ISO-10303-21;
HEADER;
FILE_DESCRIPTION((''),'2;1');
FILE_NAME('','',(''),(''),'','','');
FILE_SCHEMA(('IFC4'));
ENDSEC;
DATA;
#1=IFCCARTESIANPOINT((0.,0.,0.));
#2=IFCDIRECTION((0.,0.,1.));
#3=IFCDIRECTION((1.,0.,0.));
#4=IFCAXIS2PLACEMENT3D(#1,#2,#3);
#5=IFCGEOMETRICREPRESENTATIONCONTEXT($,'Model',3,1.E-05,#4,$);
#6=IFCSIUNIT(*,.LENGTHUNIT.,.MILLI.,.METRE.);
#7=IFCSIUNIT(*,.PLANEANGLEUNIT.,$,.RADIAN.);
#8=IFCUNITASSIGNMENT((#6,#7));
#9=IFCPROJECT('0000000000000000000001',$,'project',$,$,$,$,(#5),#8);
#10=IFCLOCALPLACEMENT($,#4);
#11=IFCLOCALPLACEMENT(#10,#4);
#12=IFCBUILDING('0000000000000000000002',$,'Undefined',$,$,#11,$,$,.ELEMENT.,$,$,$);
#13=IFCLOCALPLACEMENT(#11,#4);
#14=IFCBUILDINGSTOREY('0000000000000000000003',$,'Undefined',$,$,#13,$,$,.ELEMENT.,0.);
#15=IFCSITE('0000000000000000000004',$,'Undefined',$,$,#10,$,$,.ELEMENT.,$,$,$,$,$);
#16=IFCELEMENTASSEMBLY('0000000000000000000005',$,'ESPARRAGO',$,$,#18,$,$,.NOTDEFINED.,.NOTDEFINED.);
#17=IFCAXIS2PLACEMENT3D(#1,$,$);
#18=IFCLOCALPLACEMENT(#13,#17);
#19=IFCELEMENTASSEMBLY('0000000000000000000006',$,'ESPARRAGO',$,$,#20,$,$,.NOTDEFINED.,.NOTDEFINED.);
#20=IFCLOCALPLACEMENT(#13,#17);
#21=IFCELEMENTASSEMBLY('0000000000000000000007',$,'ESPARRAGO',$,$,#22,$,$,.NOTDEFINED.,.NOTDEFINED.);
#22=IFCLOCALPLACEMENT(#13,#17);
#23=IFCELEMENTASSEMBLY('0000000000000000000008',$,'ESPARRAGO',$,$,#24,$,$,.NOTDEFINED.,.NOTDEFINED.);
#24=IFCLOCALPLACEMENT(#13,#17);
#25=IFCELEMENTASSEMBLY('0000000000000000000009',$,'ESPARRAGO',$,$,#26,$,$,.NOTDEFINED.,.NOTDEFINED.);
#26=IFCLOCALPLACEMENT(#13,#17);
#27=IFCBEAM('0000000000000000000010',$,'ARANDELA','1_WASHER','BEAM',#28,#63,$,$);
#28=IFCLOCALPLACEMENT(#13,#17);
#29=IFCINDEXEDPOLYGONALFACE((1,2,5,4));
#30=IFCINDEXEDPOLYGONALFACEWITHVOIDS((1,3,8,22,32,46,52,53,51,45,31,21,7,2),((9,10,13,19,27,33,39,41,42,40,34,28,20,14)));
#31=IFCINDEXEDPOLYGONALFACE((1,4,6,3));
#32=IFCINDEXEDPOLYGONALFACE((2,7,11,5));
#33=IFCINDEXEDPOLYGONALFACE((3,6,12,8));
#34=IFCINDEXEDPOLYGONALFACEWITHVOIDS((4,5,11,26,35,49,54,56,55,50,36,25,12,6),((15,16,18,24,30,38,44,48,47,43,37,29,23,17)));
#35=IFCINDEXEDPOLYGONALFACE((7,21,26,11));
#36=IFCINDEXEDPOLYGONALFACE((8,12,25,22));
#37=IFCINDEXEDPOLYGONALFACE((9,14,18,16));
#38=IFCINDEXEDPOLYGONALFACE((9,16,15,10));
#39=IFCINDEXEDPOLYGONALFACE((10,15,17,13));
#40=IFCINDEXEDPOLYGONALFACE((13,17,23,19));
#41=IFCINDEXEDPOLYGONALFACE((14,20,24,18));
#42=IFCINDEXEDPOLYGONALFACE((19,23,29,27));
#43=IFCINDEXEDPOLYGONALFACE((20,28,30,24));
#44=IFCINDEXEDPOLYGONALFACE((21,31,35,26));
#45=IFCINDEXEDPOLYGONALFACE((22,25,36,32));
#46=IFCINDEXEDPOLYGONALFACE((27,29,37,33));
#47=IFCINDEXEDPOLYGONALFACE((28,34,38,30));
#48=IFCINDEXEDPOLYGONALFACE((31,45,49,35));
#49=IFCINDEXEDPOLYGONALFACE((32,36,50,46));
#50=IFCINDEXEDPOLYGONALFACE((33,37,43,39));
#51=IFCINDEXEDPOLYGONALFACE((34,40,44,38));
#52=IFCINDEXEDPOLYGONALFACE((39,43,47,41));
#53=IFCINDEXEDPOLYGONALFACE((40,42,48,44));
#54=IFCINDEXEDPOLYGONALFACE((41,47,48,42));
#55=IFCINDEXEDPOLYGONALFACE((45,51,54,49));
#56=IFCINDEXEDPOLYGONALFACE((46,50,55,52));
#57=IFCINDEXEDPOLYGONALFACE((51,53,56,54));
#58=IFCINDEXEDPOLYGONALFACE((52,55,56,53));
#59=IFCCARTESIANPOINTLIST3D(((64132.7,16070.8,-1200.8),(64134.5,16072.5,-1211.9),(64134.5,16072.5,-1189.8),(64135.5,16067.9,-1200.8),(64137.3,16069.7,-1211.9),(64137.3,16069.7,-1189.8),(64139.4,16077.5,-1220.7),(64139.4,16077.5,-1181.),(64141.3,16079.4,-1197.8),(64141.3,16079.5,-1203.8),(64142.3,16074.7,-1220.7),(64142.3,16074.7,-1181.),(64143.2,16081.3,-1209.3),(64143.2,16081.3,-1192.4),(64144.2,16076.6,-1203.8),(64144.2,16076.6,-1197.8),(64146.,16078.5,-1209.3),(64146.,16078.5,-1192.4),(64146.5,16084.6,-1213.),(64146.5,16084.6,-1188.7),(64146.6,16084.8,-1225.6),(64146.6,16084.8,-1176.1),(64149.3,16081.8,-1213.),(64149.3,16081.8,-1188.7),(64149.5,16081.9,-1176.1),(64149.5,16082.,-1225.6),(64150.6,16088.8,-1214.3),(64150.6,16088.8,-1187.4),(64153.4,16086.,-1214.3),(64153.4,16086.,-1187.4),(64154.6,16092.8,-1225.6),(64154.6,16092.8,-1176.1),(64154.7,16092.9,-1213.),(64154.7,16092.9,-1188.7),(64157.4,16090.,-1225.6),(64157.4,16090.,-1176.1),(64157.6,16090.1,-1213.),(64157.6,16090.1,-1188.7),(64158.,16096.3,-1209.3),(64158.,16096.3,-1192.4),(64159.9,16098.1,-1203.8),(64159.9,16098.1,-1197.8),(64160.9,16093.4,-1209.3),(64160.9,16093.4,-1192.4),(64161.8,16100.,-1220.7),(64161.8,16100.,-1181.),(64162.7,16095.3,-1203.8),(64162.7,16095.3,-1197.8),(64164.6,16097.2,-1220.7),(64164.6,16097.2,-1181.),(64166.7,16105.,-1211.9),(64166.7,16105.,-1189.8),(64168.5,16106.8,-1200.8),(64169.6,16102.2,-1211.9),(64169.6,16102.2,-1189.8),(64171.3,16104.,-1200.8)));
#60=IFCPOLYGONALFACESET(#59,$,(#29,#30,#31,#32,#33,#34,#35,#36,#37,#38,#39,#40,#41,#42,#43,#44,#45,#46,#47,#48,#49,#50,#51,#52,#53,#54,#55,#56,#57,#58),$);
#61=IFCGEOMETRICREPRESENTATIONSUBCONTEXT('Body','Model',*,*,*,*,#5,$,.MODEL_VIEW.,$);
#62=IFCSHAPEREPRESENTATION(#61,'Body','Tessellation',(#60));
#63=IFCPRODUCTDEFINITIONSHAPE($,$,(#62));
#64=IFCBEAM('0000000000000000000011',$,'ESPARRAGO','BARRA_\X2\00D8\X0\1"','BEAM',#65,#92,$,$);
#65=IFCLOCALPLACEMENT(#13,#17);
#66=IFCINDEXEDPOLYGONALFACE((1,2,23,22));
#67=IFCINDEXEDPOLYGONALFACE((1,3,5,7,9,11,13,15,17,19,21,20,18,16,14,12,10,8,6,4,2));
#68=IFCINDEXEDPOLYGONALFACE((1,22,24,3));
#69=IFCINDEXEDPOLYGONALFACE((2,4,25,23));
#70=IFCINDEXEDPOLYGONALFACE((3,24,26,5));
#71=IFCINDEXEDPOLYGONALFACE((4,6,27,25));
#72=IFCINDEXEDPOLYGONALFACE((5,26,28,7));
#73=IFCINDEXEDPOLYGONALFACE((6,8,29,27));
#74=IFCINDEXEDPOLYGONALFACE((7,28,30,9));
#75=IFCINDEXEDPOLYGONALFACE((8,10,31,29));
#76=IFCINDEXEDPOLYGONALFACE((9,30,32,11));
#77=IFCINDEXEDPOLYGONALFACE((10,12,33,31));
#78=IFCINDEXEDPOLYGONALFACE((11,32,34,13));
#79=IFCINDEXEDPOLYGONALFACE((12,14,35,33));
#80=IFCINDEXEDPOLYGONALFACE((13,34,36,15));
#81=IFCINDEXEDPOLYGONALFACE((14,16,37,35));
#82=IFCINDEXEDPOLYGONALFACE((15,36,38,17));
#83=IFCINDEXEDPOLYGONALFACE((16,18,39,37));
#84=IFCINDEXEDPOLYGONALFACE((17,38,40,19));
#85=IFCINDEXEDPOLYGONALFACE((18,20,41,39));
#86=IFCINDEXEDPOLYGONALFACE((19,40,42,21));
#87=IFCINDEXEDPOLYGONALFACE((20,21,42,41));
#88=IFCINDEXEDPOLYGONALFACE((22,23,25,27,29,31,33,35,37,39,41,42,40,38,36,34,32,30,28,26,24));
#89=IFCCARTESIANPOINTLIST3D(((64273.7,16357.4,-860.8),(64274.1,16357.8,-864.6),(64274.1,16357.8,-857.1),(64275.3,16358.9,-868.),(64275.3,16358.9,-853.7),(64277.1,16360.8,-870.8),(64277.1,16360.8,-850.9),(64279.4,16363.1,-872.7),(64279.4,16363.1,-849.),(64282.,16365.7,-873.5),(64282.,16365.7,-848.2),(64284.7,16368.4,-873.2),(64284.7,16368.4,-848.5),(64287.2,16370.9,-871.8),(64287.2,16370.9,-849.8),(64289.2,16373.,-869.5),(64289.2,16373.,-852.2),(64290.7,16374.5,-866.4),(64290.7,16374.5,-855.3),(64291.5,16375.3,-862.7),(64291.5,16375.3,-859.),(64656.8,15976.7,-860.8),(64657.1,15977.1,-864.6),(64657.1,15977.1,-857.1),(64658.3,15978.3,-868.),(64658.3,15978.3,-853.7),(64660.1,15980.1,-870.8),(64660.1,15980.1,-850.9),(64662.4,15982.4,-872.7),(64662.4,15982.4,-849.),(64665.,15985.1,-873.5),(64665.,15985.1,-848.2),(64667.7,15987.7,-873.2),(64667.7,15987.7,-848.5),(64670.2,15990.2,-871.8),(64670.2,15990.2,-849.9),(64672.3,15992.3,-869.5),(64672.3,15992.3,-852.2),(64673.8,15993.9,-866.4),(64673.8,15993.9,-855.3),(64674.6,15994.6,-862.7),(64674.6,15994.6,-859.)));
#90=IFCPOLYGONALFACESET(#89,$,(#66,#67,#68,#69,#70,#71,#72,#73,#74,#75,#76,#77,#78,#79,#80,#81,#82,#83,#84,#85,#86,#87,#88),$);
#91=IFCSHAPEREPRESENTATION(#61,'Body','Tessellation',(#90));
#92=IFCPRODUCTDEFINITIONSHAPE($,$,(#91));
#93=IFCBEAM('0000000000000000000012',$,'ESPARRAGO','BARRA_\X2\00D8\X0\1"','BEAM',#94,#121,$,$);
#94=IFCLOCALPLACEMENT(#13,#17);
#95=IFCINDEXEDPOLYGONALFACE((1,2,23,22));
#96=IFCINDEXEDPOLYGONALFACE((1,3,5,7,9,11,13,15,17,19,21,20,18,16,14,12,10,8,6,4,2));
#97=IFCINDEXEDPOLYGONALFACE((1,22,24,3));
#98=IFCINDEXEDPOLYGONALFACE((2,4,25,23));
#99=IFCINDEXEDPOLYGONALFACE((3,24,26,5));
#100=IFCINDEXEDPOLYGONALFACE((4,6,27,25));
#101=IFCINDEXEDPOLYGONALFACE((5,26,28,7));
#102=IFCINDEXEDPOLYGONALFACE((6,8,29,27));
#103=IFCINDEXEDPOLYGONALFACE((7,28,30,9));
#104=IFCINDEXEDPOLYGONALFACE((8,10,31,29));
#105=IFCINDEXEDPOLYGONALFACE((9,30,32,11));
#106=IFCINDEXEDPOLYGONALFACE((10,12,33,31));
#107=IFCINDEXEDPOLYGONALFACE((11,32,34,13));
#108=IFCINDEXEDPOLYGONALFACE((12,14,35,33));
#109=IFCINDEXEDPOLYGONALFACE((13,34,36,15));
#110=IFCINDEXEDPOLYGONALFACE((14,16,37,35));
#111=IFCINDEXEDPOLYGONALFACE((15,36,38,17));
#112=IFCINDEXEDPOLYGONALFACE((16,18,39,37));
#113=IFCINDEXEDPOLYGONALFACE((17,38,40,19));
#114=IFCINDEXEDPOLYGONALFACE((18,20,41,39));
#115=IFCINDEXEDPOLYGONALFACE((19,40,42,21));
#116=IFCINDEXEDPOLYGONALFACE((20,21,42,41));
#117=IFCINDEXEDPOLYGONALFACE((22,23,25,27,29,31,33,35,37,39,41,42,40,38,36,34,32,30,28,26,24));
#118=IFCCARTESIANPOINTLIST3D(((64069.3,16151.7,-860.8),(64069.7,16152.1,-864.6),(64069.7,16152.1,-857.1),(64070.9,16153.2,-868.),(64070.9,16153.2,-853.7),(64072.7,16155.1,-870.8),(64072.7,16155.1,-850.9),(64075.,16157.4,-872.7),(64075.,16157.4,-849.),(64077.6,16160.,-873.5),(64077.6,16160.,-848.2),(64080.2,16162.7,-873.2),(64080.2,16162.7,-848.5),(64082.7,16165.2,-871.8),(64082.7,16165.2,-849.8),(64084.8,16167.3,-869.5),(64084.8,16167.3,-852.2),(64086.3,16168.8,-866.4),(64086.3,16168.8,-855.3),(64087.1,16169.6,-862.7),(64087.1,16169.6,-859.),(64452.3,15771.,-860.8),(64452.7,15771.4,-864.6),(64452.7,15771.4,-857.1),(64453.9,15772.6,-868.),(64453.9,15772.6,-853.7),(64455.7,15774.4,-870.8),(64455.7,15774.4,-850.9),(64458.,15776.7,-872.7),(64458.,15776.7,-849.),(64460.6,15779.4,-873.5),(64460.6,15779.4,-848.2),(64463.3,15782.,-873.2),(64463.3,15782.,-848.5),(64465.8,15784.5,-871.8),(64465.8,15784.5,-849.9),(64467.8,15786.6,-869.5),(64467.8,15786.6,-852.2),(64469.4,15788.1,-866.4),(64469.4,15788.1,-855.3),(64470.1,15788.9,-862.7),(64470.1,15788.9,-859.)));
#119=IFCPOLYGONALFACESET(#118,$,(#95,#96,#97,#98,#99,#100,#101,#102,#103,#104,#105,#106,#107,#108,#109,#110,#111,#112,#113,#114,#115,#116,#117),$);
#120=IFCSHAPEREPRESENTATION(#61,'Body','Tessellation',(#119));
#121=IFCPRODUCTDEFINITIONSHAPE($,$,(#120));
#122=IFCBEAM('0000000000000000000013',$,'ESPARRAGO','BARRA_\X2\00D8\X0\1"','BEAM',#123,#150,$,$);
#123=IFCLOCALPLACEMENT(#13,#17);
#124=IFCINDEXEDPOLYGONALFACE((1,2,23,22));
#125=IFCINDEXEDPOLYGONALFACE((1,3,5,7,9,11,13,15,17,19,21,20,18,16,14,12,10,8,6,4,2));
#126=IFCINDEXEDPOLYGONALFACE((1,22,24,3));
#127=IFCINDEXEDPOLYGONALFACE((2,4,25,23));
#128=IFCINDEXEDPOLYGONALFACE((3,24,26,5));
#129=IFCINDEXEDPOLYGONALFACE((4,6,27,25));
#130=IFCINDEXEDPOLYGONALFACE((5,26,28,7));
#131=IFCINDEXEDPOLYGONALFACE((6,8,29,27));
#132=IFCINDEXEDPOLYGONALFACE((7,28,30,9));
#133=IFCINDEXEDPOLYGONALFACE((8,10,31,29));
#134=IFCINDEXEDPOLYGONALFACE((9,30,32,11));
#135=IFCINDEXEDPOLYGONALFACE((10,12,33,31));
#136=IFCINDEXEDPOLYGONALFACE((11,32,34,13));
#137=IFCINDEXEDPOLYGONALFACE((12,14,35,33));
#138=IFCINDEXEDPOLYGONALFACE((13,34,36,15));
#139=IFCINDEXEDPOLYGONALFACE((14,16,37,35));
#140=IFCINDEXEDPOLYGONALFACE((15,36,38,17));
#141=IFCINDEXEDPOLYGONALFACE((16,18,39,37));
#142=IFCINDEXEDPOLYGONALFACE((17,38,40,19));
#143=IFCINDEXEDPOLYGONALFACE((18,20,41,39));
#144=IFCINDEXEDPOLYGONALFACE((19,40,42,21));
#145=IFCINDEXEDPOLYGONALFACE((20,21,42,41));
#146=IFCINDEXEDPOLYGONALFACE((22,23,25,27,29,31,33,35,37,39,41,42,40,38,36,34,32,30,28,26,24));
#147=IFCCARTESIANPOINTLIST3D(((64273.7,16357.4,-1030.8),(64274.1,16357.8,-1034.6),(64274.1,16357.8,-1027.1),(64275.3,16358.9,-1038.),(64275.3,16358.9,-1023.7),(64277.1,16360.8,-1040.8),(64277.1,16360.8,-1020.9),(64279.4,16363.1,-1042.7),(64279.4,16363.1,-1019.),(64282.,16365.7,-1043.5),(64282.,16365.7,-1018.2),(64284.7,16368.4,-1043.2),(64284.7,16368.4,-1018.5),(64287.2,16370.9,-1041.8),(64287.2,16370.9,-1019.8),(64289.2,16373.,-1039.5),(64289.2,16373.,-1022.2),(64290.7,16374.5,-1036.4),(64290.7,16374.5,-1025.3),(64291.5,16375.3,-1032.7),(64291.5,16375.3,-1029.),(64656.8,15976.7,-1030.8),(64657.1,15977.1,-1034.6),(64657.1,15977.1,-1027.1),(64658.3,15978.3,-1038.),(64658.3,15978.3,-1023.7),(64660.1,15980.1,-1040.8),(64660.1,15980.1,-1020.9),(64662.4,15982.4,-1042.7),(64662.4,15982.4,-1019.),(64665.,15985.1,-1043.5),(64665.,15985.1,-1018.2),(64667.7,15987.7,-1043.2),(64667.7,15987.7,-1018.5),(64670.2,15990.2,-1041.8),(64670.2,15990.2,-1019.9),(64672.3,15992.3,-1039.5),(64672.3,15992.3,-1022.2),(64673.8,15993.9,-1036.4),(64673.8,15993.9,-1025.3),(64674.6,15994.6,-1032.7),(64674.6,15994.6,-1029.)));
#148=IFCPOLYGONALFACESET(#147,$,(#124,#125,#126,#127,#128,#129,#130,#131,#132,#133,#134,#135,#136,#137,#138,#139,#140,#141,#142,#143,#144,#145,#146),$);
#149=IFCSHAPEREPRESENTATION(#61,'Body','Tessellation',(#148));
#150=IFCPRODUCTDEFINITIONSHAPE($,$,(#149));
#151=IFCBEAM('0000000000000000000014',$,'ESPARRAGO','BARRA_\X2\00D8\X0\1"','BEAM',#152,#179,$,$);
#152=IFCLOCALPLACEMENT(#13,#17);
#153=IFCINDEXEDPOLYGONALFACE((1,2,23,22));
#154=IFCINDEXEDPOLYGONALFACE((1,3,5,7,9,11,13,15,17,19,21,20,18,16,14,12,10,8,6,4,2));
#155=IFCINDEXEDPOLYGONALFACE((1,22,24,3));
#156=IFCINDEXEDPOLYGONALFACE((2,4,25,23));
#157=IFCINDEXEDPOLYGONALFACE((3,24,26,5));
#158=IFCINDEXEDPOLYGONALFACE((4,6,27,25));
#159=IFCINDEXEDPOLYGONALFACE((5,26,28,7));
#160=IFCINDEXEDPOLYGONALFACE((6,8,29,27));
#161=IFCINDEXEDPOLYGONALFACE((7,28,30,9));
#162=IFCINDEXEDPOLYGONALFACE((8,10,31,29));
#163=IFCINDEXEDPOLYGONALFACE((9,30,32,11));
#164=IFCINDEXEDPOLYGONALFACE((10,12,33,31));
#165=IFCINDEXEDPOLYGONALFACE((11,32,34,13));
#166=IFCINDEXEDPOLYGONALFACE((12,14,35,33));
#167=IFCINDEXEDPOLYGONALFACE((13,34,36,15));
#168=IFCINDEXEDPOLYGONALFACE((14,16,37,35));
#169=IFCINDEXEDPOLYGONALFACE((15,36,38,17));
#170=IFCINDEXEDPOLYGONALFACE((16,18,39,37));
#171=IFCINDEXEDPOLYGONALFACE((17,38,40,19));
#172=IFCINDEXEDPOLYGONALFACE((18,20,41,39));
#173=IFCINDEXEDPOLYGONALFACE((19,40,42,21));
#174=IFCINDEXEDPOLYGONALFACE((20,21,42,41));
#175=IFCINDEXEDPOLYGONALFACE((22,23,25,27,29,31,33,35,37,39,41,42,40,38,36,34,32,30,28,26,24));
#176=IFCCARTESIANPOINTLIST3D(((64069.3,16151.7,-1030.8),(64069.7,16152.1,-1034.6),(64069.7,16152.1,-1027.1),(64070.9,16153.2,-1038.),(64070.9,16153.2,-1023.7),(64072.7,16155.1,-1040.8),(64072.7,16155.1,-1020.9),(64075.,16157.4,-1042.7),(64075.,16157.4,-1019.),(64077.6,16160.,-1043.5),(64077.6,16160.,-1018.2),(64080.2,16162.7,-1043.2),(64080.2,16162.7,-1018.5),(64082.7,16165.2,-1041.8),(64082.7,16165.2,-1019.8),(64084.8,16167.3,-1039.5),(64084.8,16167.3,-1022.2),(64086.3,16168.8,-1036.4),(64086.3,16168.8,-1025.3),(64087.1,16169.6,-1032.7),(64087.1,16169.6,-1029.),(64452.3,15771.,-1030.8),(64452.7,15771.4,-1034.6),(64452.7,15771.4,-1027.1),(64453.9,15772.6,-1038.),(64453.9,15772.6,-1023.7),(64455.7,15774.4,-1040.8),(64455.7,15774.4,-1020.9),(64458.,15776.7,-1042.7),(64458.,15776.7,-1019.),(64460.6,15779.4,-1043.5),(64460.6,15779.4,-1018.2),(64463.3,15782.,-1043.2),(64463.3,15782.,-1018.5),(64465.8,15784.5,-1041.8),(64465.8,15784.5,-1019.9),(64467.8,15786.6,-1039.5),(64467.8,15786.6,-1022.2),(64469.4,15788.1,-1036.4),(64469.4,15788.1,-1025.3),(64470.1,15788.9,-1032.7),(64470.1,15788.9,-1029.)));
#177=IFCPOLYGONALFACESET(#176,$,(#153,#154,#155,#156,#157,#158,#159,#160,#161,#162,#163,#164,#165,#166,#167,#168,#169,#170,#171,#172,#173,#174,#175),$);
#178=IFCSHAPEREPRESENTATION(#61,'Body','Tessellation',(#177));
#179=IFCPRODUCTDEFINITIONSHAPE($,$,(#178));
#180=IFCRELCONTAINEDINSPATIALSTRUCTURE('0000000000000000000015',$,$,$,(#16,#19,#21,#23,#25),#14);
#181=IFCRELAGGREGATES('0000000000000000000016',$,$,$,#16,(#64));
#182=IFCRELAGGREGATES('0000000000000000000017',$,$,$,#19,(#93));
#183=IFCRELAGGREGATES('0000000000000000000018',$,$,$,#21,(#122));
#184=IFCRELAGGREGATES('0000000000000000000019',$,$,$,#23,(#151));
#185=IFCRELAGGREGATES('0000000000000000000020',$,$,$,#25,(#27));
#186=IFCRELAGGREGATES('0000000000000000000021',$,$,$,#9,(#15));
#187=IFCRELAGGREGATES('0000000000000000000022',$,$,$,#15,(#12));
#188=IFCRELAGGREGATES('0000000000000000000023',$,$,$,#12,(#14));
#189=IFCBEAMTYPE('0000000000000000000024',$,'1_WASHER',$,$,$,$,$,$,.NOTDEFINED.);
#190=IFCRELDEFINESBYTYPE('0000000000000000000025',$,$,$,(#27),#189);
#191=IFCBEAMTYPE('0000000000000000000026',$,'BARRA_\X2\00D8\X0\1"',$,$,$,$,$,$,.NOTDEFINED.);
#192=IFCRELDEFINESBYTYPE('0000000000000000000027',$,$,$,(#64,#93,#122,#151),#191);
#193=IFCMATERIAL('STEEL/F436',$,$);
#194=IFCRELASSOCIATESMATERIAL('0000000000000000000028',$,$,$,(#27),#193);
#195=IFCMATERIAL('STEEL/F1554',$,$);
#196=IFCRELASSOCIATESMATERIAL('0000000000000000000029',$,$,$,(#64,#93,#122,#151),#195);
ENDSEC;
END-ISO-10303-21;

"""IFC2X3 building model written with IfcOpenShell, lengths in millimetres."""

from ifc_helpers import new_model, si_unit, frame, origin_with_axes, origin_2d_with_axis, place, context, subcontext, project, spatial, polyline, circle, outline, extrude, material, type_object, element, aggregate, save


model = new_model("IFC2X3")

# Units and contexts
model_context = context("Model", 3, precision=1e-05, world=origin_with_axes())
body_context = subcontext(model_context, "Body", "Model", "MODEL_VIEW")
ifc_project = project(units=[si_unit("LENGTHUNIT", "METRE", prefix="MILLI"), si_unit("PLANEANGLEUNIT", "RADIAN")], contexts=[model_context])

# Site, building, storey
site_placement = place(None, origin_with_axes())
site = spatial("IfcSite", under=ifc_project, at=site_placement, Name="Undefined", CompositionType="ELEMENT")
building_placement = place(site_placement, origin_with_axes())
building = spatial("IfcBuilding", under=site, at=building_placement, Name="Undefined", CompositionType="ELEMENT")
storey_placement = place(building_placement, origin_with_axes())
storey = spatial("IfcBuildingStorey", under=building, at=storey_placement, Name="Undefined", CompositionType="ELEMENT", Elevation=0.0)

# Element assemblies
assembly_1_placement = place(storey_placement, origin_with_axes())
assembly_1 = element("IfcElementAssembly", 1, at=assembly_1_placement, inside=storey, Name="ESPARRAGO", AssemblyPlace="NOTDEFINED", PredefinedType="NOTDEFINED")
assembly_2_placement = place(storey_placement, origin_with_axes())
assembly_2 = element("IfcElementAssembly", 2, at=assembly_2_placement, inside=storey, Name="ESPARRAGO", AssemblyPlace="NOTDEFINED", PredefinedType="NOTDEFINED")
assembly_3_placement = place(storey_placement, origin_with_axes())
assembly_3 = element("IfcElementAssembly", 3, at=assembly_3_placement, inside=storey, Name="ESPARRAGO", AssemblyPlace="NOTDEFINED", PredefinedType="NOTDEFINED")
assembly_4_placement = place(storey_placement, origin_with_axes())
assembly_4 = element("IfcElementAssembly", 4, at=assembly_4_placement, inside=storey, Name="ESPARRAGO", AssemblyPlace="NOTDEFINED", PredefinedType="NOTDEFINED")

# Element assembly
assembly_5_placement = place(storey_placement, origin_with_axes())
assembly_5 = element("IfcElementAssembly", 5, at=assembly_5_placement, inside=storey, Name="ESPARRAGO", AssemblyPlace="NOTDEFINED", PredefinedType="NOTDEFINED")

# Beams
ifc_material_1 = material(Name="STEEL/F436")
beam_type_1 = type_object("IfcBeamType", Name="1_WASHER", PredefinedType="NOTDEFINED")
beam_1_placement = place(assembly_5_placement, frame((64150.6, 16088.8, -1200.8), z_axis=(0.000061, -0.000061, 1.0), x_axis=(0.709311, -0.704895, -0.000086)))
beam_1 = element("IfcBeam", 6, at=beam_1_placement, type_object=beam_type_1, material=ifc_material_1, Name="ARANDELA", Description="1_WASHER", ObjectType="BEAM", context=body_context, shape_type="SweptSolid", body=[
    extrude(outline(polyline([(-15.8, -19.9), (-22.9, -11.0), (-25.4, 0.0), (-22.9, 11.0), (-15.8, 19.9), (-5.7, 24.8), (5.7, 24.8), (15.8, 19.9), (22.9, 11.0), (25.4, 0.0), (22.9, -11.0), (15.8, -19.9), (5.7, -24.8), (-5.7, -24.8), (-15.8, -19.9)]), holes=[polyline([(-5.9, 12.2), (-10.5, 8.4), (-13.2, 3.0), (-13.2, -3.0), (-10.5, -8.4), (-5.9, -12.2), (0.0, -13.5), (5.9, -12.2), (10.5, -8.4), (13.2, -3.0), (13.2, 3.0), (10.5, 8.4), (5.9, 12.2), (0.0, 13.5), (-5.9, 12.2)])]), frame((4.0, 0.0, 0.0), z_axis=(-1.0, 0.0, 0.0), x_axis=(0.0, -1.0, 0.0)), (0.0, 0.0, 1.0), 4.0),
])
ifc_material_2 = material(Name="STEEL/F1554")
beam_type_2 = type_object("IfcBeamType", Name="BARRA_Ø1\"", PredefinedType="NOTDEFINED")
beam_2_placement = place(assembly_1_placement, frame((64282.7, 16366.4, -860.8), z_axis=(0.000003, -0.000003, 1.0), x_axis=(0.709313, -0.704893, -0.000004)))
beam_2 = element("IfcBeam", 7, at=beam_2_placement, type_object=beam_type_2, material=ifc_material_2, Name="ESPARRAGO", Description="BARRA_Ø1\"", ObjectType="BEAM", context=body_context, shape_type="SweptSolid", body=[
    extrude(circle(Radius=12.7, at=origin_2d_with_axis()), frame((540.0, 0.0, 0.0), z_axis=(-1.0, 0.0, 0.0), x_axis=(0.0, -1.0, 0.0)), (0.0, 0.0, 1.0), 540.0),
])
aggregate(assembly_1, [beam_2])
beam_3_placement = place(assembly_2_placement, frame((64078.3, 16160.7, -860.8), z_axis=(0.000003, -0.000003, 1.0), x_axis=(0.709313, -0.704893, -0.000004)))
beam_3 = element("IfcBeam", 8, at=beam_3_placement, type_object=beam_type_2, material=ifc_material_2, Name="ESPARRAGO", Description="BARRA_Ø1\"", ObjectType="BEAM", context=body_context, shape_type="SweptSolid", body=[
    extrude(circle(Radius=12.7, at=origin_2d_with_axis()), frame((540.0, 0.0, 0.0), z_axis=(-1.0, 0.0, 0.0), x_axis=(0.0, -1.0, 0.0)), (0.0, 0.0, 1.0), 540.0),
])
aggregate(assembly_2, [beam_3])
beam_4_placement = place(assembly_3_placement, frame((64282.7, 16366.4, -1030.8), z_axis=(0.000003, -0.000003, 1.0), x_axis=(0.709313, -0.704893, -0.000004)))
beam_4 = element("IfcBeam", 9, at=beam_4_placement, type_object=beam_type_2, material=ifc_material_2, Name="ESPARRAGO", Description="BARRA_Ø1\"", ObjectType="BEAM", context=body_context, shape_type="SweptSolid", body=[
    extrude(circle(Radius=12.7, at=origin_2d_with_axis()), frame((540.0, 0.0, 0.0), z_axis=(-1.0, 0.0, 0.0), x_axis=(0.0, -1.0, 0.0)), (0.0, 0.0, 1.0), 540.0),
])
aggregate(assembly_3, [beam_4])
beam_5_placement = place(assembly_4_placement, frame((64078.3, 16160.7, -1030.8), z_axis=(0.000003, -0.000003, 1.0), x_axis=(0.709313, -0.704893, -0.000004)))
beam_5 = element("IfcBeam", 10, at=beam_5_placement, type_object=beam_type_2, material=ifc_material_2, Name="ESPARRAGO", Description="BARRA_Ø1\"", ObjectType="BEAM", context=body_context, shape_type="SweptSolid", body=[
    extrude(circle(Radius=12.7, at=origin_2d_with_axis()), frame((540.0, 0.0, 0.0), z_axis=(-1.0, 0.0, 0.0), x_axis=(0.0, -1.0, 0.0)), (0.0, 0.0, 1.0), 540.0),
])
aggregate(assembly_4, [beam_5])
aggregate(assembly_5, [beam_1])

save(model, "model.ifc")
